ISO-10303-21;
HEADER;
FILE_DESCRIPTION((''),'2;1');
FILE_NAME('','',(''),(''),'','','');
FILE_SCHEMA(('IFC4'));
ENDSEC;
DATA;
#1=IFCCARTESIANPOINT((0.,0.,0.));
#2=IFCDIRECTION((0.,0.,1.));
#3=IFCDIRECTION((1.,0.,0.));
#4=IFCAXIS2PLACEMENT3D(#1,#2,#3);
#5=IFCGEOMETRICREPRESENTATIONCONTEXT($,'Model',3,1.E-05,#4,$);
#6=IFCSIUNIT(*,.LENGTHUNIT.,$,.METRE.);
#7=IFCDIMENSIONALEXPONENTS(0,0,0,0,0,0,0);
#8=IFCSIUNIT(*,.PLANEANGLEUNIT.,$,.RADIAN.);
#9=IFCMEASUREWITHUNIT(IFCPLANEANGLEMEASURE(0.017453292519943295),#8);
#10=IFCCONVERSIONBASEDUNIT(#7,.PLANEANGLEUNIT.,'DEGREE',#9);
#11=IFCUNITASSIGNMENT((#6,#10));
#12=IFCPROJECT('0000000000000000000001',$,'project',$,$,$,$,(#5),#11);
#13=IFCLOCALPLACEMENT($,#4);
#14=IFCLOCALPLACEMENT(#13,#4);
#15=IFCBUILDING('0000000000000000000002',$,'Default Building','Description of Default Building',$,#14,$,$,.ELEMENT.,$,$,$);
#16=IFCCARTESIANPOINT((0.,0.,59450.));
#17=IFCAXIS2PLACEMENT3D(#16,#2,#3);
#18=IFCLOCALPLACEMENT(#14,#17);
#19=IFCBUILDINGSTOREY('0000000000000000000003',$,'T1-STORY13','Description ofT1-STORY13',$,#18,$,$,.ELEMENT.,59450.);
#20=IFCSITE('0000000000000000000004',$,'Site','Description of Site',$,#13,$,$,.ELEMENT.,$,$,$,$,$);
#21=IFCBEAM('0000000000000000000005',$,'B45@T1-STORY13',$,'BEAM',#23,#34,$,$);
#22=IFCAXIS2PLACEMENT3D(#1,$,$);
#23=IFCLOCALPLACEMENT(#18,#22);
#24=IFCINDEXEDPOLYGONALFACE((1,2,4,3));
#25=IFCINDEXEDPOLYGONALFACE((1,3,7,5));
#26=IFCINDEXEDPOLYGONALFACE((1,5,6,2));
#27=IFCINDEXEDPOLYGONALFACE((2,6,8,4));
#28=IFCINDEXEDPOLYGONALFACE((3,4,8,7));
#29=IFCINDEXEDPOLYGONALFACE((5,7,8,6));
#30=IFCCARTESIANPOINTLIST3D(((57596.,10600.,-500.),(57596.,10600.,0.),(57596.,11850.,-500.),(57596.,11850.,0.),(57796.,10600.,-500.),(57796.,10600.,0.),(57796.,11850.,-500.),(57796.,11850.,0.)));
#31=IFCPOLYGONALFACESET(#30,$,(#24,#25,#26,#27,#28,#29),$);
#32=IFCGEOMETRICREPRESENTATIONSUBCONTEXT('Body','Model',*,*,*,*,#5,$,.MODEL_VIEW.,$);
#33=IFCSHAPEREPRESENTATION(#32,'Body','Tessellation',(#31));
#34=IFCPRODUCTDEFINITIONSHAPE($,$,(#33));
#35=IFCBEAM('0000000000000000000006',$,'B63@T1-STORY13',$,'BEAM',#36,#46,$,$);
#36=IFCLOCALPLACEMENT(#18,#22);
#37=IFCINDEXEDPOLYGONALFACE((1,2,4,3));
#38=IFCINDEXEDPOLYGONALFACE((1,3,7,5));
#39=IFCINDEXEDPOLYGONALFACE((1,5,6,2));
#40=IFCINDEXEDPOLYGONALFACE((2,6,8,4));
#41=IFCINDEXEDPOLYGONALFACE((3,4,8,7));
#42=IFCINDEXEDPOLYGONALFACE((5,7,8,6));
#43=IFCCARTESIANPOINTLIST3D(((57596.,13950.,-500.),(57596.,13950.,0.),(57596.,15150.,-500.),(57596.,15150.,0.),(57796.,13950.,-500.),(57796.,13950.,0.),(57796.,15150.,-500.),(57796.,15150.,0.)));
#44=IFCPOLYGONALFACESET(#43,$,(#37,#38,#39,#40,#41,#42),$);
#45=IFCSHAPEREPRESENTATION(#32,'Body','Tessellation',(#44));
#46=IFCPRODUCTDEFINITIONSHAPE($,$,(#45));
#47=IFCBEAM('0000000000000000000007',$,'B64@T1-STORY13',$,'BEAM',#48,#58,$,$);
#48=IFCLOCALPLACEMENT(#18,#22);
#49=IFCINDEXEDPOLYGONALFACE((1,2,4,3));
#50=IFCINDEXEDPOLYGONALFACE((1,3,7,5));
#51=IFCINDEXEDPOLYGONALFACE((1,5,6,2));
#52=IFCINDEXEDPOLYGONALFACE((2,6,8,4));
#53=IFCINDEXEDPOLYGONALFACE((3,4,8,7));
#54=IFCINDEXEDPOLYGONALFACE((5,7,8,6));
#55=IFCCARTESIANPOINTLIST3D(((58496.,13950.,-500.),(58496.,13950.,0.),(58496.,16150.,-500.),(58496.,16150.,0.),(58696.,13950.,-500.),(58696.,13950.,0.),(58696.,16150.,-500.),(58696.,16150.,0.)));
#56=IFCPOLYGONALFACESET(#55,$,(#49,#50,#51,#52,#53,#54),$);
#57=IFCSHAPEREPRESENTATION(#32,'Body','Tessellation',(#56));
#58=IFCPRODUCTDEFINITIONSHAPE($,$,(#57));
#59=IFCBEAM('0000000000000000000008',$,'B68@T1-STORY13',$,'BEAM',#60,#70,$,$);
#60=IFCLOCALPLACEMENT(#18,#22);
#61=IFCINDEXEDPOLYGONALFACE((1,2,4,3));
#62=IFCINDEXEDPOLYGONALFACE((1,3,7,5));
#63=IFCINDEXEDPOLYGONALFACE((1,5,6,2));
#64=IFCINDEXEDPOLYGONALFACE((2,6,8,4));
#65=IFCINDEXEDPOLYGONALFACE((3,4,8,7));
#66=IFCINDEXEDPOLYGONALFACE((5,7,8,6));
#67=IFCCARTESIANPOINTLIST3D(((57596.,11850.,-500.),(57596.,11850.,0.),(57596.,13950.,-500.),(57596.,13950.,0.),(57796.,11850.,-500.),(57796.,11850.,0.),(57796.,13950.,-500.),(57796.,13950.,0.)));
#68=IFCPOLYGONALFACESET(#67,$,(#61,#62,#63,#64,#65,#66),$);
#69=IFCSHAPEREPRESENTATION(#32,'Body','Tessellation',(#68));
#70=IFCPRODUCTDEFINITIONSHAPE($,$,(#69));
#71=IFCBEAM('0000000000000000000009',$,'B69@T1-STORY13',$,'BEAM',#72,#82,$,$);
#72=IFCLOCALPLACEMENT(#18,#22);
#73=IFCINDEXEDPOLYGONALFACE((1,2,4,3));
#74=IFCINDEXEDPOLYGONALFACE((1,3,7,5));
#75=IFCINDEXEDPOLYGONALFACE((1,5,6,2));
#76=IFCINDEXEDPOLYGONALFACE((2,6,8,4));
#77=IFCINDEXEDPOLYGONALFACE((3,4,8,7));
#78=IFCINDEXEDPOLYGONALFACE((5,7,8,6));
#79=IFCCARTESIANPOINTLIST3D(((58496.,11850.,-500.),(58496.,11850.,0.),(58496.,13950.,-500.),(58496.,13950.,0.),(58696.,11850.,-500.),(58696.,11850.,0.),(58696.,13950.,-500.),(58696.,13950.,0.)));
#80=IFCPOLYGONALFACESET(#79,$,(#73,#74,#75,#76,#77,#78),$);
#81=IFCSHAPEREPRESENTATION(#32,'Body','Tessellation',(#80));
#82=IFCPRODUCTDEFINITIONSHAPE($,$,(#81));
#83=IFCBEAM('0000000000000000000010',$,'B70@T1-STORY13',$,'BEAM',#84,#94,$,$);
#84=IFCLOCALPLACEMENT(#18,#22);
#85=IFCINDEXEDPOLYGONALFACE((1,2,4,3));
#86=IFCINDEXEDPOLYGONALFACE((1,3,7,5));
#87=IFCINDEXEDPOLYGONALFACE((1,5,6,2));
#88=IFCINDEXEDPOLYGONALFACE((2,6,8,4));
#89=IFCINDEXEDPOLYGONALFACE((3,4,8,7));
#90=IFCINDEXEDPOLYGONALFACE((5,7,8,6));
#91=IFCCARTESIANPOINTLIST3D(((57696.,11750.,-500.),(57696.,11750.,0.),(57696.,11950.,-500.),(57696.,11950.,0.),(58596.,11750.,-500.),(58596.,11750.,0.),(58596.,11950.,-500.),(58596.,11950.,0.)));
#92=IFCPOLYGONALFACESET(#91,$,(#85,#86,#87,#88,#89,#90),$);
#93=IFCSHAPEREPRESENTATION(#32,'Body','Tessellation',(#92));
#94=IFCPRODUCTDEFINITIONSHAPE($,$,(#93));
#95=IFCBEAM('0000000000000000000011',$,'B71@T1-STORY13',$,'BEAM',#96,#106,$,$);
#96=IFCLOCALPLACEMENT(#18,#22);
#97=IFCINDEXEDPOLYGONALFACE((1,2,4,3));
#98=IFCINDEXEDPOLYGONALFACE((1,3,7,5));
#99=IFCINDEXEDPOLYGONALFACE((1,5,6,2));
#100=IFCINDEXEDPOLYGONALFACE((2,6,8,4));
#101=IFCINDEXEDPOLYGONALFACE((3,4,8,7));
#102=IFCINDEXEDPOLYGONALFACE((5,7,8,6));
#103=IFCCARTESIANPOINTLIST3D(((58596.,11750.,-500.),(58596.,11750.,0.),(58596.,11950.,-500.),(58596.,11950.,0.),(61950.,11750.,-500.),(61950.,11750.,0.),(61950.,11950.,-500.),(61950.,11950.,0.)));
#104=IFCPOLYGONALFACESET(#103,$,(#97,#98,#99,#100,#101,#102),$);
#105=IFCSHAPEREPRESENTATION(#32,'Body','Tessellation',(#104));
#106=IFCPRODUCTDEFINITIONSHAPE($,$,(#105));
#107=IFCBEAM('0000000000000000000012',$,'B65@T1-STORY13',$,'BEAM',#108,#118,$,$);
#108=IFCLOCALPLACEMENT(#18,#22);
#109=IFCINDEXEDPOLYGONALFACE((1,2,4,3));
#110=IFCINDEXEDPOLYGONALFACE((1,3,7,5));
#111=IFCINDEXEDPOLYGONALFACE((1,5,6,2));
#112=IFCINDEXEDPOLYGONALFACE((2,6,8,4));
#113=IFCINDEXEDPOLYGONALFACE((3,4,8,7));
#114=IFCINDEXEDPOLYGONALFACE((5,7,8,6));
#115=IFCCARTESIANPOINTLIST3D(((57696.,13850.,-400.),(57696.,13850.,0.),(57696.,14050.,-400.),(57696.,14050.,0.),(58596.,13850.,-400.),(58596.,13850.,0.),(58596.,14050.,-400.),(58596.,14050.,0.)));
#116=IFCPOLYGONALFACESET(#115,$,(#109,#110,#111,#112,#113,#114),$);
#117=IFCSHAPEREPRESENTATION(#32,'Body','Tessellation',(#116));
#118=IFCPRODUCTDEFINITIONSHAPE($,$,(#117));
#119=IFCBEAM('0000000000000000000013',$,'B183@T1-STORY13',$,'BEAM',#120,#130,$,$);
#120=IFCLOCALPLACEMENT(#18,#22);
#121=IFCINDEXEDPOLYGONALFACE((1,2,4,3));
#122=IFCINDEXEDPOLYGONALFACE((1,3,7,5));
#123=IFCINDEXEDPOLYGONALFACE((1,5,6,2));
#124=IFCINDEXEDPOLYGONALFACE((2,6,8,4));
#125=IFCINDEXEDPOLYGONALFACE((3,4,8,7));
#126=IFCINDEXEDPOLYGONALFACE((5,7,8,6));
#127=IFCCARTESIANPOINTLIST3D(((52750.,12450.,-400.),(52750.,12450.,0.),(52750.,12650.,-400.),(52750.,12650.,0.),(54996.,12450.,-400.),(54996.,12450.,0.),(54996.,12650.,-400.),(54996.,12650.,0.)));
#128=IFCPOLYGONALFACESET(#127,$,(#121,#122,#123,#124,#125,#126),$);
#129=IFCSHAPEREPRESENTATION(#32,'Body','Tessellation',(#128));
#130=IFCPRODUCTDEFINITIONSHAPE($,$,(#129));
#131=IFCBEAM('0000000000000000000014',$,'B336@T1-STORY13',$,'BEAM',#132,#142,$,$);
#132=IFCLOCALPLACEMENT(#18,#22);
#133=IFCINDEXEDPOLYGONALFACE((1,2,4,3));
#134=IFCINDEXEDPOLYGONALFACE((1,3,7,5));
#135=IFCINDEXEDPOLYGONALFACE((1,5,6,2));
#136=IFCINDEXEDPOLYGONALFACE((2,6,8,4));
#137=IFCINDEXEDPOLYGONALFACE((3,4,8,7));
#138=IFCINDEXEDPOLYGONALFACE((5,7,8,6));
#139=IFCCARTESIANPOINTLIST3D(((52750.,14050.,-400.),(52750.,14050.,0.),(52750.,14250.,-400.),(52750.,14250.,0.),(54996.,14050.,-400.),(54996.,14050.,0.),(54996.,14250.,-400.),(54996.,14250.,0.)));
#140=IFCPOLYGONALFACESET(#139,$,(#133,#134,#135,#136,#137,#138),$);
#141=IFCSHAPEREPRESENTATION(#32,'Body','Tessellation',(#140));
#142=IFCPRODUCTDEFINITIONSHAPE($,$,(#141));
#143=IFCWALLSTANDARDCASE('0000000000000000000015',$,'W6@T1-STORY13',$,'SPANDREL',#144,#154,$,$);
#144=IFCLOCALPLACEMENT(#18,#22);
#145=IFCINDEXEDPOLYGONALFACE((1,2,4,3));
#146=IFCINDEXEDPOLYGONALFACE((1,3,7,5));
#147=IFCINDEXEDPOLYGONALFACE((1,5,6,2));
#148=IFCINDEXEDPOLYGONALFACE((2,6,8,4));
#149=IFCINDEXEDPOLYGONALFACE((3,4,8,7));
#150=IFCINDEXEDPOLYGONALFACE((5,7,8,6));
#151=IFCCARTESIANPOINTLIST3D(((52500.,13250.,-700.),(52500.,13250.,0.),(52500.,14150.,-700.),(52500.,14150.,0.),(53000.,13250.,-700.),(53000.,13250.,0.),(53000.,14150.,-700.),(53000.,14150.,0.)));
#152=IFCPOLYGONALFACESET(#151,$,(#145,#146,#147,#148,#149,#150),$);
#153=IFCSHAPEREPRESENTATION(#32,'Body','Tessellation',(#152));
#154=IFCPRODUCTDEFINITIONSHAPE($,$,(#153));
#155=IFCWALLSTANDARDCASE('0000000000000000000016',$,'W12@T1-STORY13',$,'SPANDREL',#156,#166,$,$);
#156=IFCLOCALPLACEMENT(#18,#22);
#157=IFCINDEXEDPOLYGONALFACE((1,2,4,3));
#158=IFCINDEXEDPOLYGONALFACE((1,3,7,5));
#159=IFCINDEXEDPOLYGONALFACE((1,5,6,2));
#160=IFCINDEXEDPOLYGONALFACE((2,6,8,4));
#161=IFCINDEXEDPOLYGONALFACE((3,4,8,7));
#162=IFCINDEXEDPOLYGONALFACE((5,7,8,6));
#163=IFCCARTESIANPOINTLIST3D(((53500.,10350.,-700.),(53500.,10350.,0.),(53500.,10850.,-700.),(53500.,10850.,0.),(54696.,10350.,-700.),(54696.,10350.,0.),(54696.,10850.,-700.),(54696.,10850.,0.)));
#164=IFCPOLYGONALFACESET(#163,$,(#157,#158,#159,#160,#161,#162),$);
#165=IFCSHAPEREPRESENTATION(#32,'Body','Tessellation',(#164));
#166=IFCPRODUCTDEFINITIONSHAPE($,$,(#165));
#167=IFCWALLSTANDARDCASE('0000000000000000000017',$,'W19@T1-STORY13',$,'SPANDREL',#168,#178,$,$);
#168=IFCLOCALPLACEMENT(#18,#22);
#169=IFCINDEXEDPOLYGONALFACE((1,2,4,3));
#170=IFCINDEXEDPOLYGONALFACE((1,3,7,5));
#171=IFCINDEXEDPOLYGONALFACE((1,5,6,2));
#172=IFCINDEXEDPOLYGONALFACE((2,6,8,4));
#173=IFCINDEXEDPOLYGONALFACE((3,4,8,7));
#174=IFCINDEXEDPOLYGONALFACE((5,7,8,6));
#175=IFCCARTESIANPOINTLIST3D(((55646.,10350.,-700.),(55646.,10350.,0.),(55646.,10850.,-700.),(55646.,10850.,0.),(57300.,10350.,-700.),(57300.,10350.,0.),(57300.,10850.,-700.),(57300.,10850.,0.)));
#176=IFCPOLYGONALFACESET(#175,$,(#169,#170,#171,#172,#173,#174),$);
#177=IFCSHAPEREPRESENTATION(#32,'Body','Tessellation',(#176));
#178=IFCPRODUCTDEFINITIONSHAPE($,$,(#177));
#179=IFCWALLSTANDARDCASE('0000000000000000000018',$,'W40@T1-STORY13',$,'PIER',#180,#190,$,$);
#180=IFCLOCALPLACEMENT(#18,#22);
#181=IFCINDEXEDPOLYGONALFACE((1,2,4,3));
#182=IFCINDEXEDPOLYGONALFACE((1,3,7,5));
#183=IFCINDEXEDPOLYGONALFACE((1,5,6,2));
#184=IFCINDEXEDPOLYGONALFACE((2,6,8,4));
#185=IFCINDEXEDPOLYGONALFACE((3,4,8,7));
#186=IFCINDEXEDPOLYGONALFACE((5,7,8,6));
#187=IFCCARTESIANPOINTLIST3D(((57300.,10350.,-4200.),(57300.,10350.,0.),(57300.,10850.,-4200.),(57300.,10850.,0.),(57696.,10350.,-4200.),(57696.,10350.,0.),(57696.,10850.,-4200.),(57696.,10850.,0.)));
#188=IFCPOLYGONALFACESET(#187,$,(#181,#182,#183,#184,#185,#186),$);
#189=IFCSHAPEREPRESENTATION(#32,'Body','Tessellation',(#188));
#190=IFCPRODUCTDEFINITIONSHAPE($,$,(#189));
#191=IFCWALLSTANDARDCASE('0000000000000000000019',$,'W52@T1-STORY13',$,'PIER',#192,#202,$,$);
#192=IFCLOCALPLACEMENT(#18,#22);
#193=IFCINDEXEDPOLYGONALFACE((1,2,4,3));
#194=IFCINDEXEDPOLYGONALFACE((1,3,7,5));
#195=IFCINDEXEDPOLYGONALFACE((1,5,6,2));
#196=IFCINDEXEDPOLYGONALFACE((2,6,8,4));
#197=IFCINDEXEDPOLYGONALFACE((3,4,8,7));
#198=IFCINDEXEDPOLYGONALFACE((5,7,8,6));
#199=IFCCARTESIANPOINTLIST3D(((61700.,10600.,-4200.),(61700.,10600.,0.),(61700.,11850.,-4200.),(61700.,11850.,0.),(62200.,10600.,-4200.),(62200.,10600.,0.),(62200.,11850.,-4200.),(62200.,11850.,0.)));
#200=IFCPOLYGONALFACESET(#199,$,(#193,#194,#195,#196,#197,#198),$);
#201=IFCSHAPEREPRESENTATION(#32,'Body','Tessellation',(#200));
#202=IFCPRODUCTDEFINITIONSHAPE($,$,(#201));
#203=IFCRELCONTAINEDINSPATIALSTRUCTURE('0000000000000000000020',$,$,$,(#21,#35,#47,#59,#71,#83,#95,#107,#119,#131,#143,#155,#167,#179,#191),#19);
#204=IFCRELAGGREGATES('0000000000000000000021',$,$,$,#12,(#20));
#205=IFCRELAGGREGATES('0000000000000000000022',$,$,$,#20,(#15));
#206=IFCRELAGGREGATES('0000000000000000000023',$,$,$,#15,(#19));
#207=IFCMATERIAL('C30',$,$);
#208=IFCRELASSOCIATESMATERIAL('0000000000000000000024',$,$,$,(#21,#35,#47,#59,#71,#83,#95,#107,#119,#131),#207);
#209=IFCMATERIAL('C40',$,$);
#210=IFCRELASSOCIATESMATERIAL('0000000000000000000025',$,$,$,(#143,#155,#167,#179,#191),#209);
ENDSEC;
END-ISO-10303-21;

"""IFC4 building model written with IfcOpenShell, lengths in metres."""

from ifc_helpers import new_model, entity, si_unit, converted_unit, frame, origin_with_axes, place, context, subcontext, project, spatial, indexed_curve, rectangle, outline, extrude, material, element, save


model = new_model("IFC4")

# Units and contexts
model_context = context("Model", 3, precision=1e-05, world=origin_with_axes())
body_context = subcontext(model_context, "Body", "Model", "MODEL_VIEW")
ifc_project = project(units=[si_unit("LENGTHUNIT", "METRE"), converted_unit("PLANEANGLEUNIT", "DEGREE", entity("IfcPlaneAngleMeasure", 0.017453292519943295), si_unit("PLANEANGLEUNIT", "RADIAN"), dimensions=[0, 0, 0, 0, 0, 0, 0])], contexts=[model_context])

# Site, building, storey
site_placement = place(None, origin_with_axes())
site = spatial("IfcSite", under=ifc_project, at=site_placement, Name="Site", Description="Description of Site", CompositionType="ELEMENT")
building_placement = place(site_placement, origin_with_axes())
building = spatial("IfcBuilding", under=site, at=building_placement, Name="Default Building", Description="Description of Default Building", CompositionType="ELEMENT")
storey_placement = place(building_placement, frame((0.0, 0.0, 59450.0), z_axis=(0.0, 0.0, 1.0), x_axis=(1.0, 0.0, 0.0)))
storey = spatial("IfcBuildingStorey", under=building, at=storey_placement, Name="T1-STORY13", Description="Description ofT1-STORY13", CompositionType="ELEMENT", Elevation=59450.0)

# Beams
ifc_material_1 = material(Name="C30")
beam_1_placement = place(storey_placement, frame((57696.0, 10600.0, -250.0), z_axis=(0.0, 1.0, 0.0), x_axis=(-1.0, 0.0, 0.0)))
element("IfcBeam", 1, at=beam_1_placement, inside=storey, material=ifc_material_1, Name="B45@T1-STORY13", ObjectType="BEAM", context=body_context, shape_type="SweptSolid", body=[
    extrude(rectangle(XDim=200.0, YDim=500.0), origin_with_axes(), (0.0, 0.0, 1.0), 1250.0),
])
beam_2_placement = place(storey_placement, frame((57696.0, 13950.0, -250.0), z_axis=(0.0, 1.0, 0.0), x_axis=(-1.0, 0.0, 0.0)))
element("IfcBeam", 2, at=beam_2_placement, inside=storey, material=ifc_material_1, Name="B63@T1-STORY13", ObjectType="BEAM", context=body_context, shape_type="SweptSolid", body=[
    extrude(rectangle(XDim=200.0, YDim=500.0), origin_with_axes(), (0.0, 0.0, 1.0), 1200.0),
])
beam_3_placement = place(storey_placement, frame((58596.0, 13950.0, -250.0), z_axis=(0.0, 1.0, 0.0), x_axis=(-1.0, 0.0, 0.0)))
element("IfcBeam", 3, at=beam_3_placement, inside=storey, material=ifc_material_1, Name="B64@T1-STORY13", ObjectType="BEAM", context=body_context, shape_type="SweptSolid", body=[
    extrude(rectangle(XDim=200.0, YDim=500.0), origin_with_axes(), (0.0, 0.0, 1.0), 2200.0),
])
for number, where, z_axis, x_axis, name in (
    (4, (57696.0, 11850.0, -250.0), (0.0, 1.0, 0.0), (-1.0, 0.0, 0.0), "B68@T1-STORY13"),
    (5, (58596.0, 11850.0, -250.0), (0.0, 1.0, 0.0), (-1.0, 0.0, 0.0), "B69@T1-STORY13"),
):
    element("IfcBeam", number, at=place(storey_placement, frame(where, z_axis=z_axis, x_axis=x_axis)), inside=storey, material=ifc_material_1, Name=name, ObjectType="BEAM", context=body_context, shape_type="SweptSolid", body=[
        extrude(rectangle(XDim=200.0, YDim=500.0), origin_with_axes(), (0.0, 0.0, 1.0), 2100.0),
    ])
beam_4_placement = place(storey_placement, frame((57696.0, 11850.0, -250.0), z_axis=(1.0, 0.0, 0.0), x_axis=(0.0, 1.0, 0.0)))
element("IfcBeam", 6, at=beam_4_placement, inside=storey, material=ifc_material_1, Name="B70@T1-STORY13", ObjectType="BEAM", context=body_context, shape_type="SweptSolid", body=[
    extrude(rectangle(XDim=200.0, YDim=500.0), origin_with_axes(), (0.0, 0.0, 1.0), 900.0),
])
beam_5_placement = place(storey_placement, frame((58596.0, 11850.0, -250.0), z_axis=(1.0, 0.0, 0.0), x_axis=(0.0, 1.0, 0.0)))
element("IfcBeam", 7, at=beam_5_placement, inside=storey, material=ifc_material_1, Name="B71@T1-STORY13", ObjectType="BEAM", context=body_context, shape_type="SweptSolid", body=[
    extrude(rectangle(XDim=200.0, YDim=500.0), origin_with_axes(), (0.0, 0.0, 1.0), 3354.0),
])
beam_6_placement = place(storey_placement, frame((57696.0, 13950.0, -200.0), z_axis=(1.0, 0.0, 0.0), x_axis=(0.0, 1.0, 0.0)))
element("IfcBeam", 8, at=beam_6_placement, inside=storey, material=ifc_material_1, Name="B65@T1-STORY13", ObjectType="BEAM", context=body_context, shape_type="SweptSolid", body=[
    extrude(rectangle(XDim=200.0, YDim=400.0), origin_with_axes(), (0.0, 0.0, 1.0), 900.0),
])
for number, where, z_axis, x_axis, name in (
    (9, (52750.0, 12550.0, -200.0), (1.0, 0.0, 0.0), (0.0, 1.0, 0.0), "B183@T1-STORY13"),
    (10, (52750.0, 14150.0, -200.0), (1.0, 0.0, 0.0), (0.0, 1.0, 0.0), "B336@T1-STORY13"),
):
    element("IfcBeam", number, at=place(storey_placement, frame(where, z_axis=z_axis, x_axis=x_axis)), inside=storey, material=ifc_material_1, Name=name, ObjectType="BEAM", context=body_context, shape_type="SweptSolid", body=[
        extrude(rectangle(XDim=200.0, YDim=400.0), origin_with_axes(), (0.0, 0.0, 1.0), 2246.0),
    ])

# Walls
ifc_material_2 = material(Name="C40")
wall_1_placement = place(storey_placement, frame((52750.0, 13250.0, -700.0), z_axis=(0.0, 0.0, 1.0), x_axis=(0.0, 1.0, 0.0)))
element("IfcWallStandardCase", 11, at=wall_1_placement, inside=storey, material=ifc_material_2, Name="W6@T1-STORY13", ObjectType="SPANDREL", context=body_context, shape_type="SweptSolid", body=[
    extrude(outline(indexed_curve([(0.0, -250.0), (0.0, 250.0), (900.0, 250.0), (900.0, -250.0), (0.0, -250.0)], self_intersect=False)), origin_with_axes(), (0.0, 0.0, 1.0), 700.0),
])
wall_2_placement = place(storey_placement, frame((53500.0, 10600.0, -700.0), z_axis=(0.0, 0.0, 1.0), x_axis=(1.0, 0.0, 0.0)))
element("IfcWallStandardCase", 12, at=wall_2_placement, inside=storey, material=ifc_material_2, Name="W12@T1-STORY13", ObjectType="SPANDREL", context=body_context, shape_type="SweptSolid", body=[
    extrude(outline(indexed_curve([(0.0, -250.0), (0.0, 250.0), (1196.0, 250.0), (1196.0, -250.0), (0.0, -250.0)], self_intersect=False)), origin_with_axes(), (0.0, 0.0, 1.0), 700.0),
])
wall_3_placement = place(storey_placement, frame((55646.0, 10600.0, -700.0), z_axis=(0.0, 0.0, 1.0), x_axis=(1.0, 0.0, 0.0)))
element("IfcWallStandardCase", 13, at=wall_3_placement, inside=storey, material=ifc_material_2, Name="W19@T1-STORY13", ObjectType="SPANDREL", context=body_context, shape_type="SweptSolid", body=[
    extrude(outline(indexed_curve([(0.0, -250.0), (0.0, 250.0), (1654.0, 250.0), (1654.0, -250.0), (0.0, -250.0)], self_intersect=False)), origin_with_axes(), (0.0, 0.0, 1.0), 700.0),
])
wall_4_placement = place(storey_placement, frame((57300.0, 10600.0, -4200.0), z_axis=(0.0, 0.0, 1.0), x_axis=(1.0, 0.0, 0.0)))
element("IfcWallStandardCase", 14, at=wall_4_placement, inside=storey, material=ifc_material_2, Name="W40@T1-STORY13", ObjectType="PIER", context=body_context, shape_type="SweptSolid", body=[
    extrude(outline(indexed_curve([(0.0, -250.0), (0.0, 250.0), (396.0, 250.0), (396.0, -250.0), (0.0, -250.0)], self_intersect=False)), origin_with_axes(), (0.0, 0.0, 1.0), 4200.0),
])
wall_5_placement = place(storey_placement, frame((61950.0, 10600.0, -4200.0), z_axis=(0.0, 0.0, 1.0), x_axis=(0.0, 1.0, 0.0)))
element("IfcWallStandardCase", 15, at=wall_5_placement, inside=storey, material=ifc_material_2, Name="W52@T1-STORY13", ObjectType="PIER", context=body_context, shape_type="SweptSolid", body=[
    extrude(outline(indexed_curve([(0.0, -250.0), (0.0, 250.0), (1250.0, 250.0), (1250.0, -250.0), (0.0, -250.0)], self_intersect=False)), origin_with_axes(), (0.0, 0.0, 1.0), 4200.0),
])

save(model, "model.ifc")
